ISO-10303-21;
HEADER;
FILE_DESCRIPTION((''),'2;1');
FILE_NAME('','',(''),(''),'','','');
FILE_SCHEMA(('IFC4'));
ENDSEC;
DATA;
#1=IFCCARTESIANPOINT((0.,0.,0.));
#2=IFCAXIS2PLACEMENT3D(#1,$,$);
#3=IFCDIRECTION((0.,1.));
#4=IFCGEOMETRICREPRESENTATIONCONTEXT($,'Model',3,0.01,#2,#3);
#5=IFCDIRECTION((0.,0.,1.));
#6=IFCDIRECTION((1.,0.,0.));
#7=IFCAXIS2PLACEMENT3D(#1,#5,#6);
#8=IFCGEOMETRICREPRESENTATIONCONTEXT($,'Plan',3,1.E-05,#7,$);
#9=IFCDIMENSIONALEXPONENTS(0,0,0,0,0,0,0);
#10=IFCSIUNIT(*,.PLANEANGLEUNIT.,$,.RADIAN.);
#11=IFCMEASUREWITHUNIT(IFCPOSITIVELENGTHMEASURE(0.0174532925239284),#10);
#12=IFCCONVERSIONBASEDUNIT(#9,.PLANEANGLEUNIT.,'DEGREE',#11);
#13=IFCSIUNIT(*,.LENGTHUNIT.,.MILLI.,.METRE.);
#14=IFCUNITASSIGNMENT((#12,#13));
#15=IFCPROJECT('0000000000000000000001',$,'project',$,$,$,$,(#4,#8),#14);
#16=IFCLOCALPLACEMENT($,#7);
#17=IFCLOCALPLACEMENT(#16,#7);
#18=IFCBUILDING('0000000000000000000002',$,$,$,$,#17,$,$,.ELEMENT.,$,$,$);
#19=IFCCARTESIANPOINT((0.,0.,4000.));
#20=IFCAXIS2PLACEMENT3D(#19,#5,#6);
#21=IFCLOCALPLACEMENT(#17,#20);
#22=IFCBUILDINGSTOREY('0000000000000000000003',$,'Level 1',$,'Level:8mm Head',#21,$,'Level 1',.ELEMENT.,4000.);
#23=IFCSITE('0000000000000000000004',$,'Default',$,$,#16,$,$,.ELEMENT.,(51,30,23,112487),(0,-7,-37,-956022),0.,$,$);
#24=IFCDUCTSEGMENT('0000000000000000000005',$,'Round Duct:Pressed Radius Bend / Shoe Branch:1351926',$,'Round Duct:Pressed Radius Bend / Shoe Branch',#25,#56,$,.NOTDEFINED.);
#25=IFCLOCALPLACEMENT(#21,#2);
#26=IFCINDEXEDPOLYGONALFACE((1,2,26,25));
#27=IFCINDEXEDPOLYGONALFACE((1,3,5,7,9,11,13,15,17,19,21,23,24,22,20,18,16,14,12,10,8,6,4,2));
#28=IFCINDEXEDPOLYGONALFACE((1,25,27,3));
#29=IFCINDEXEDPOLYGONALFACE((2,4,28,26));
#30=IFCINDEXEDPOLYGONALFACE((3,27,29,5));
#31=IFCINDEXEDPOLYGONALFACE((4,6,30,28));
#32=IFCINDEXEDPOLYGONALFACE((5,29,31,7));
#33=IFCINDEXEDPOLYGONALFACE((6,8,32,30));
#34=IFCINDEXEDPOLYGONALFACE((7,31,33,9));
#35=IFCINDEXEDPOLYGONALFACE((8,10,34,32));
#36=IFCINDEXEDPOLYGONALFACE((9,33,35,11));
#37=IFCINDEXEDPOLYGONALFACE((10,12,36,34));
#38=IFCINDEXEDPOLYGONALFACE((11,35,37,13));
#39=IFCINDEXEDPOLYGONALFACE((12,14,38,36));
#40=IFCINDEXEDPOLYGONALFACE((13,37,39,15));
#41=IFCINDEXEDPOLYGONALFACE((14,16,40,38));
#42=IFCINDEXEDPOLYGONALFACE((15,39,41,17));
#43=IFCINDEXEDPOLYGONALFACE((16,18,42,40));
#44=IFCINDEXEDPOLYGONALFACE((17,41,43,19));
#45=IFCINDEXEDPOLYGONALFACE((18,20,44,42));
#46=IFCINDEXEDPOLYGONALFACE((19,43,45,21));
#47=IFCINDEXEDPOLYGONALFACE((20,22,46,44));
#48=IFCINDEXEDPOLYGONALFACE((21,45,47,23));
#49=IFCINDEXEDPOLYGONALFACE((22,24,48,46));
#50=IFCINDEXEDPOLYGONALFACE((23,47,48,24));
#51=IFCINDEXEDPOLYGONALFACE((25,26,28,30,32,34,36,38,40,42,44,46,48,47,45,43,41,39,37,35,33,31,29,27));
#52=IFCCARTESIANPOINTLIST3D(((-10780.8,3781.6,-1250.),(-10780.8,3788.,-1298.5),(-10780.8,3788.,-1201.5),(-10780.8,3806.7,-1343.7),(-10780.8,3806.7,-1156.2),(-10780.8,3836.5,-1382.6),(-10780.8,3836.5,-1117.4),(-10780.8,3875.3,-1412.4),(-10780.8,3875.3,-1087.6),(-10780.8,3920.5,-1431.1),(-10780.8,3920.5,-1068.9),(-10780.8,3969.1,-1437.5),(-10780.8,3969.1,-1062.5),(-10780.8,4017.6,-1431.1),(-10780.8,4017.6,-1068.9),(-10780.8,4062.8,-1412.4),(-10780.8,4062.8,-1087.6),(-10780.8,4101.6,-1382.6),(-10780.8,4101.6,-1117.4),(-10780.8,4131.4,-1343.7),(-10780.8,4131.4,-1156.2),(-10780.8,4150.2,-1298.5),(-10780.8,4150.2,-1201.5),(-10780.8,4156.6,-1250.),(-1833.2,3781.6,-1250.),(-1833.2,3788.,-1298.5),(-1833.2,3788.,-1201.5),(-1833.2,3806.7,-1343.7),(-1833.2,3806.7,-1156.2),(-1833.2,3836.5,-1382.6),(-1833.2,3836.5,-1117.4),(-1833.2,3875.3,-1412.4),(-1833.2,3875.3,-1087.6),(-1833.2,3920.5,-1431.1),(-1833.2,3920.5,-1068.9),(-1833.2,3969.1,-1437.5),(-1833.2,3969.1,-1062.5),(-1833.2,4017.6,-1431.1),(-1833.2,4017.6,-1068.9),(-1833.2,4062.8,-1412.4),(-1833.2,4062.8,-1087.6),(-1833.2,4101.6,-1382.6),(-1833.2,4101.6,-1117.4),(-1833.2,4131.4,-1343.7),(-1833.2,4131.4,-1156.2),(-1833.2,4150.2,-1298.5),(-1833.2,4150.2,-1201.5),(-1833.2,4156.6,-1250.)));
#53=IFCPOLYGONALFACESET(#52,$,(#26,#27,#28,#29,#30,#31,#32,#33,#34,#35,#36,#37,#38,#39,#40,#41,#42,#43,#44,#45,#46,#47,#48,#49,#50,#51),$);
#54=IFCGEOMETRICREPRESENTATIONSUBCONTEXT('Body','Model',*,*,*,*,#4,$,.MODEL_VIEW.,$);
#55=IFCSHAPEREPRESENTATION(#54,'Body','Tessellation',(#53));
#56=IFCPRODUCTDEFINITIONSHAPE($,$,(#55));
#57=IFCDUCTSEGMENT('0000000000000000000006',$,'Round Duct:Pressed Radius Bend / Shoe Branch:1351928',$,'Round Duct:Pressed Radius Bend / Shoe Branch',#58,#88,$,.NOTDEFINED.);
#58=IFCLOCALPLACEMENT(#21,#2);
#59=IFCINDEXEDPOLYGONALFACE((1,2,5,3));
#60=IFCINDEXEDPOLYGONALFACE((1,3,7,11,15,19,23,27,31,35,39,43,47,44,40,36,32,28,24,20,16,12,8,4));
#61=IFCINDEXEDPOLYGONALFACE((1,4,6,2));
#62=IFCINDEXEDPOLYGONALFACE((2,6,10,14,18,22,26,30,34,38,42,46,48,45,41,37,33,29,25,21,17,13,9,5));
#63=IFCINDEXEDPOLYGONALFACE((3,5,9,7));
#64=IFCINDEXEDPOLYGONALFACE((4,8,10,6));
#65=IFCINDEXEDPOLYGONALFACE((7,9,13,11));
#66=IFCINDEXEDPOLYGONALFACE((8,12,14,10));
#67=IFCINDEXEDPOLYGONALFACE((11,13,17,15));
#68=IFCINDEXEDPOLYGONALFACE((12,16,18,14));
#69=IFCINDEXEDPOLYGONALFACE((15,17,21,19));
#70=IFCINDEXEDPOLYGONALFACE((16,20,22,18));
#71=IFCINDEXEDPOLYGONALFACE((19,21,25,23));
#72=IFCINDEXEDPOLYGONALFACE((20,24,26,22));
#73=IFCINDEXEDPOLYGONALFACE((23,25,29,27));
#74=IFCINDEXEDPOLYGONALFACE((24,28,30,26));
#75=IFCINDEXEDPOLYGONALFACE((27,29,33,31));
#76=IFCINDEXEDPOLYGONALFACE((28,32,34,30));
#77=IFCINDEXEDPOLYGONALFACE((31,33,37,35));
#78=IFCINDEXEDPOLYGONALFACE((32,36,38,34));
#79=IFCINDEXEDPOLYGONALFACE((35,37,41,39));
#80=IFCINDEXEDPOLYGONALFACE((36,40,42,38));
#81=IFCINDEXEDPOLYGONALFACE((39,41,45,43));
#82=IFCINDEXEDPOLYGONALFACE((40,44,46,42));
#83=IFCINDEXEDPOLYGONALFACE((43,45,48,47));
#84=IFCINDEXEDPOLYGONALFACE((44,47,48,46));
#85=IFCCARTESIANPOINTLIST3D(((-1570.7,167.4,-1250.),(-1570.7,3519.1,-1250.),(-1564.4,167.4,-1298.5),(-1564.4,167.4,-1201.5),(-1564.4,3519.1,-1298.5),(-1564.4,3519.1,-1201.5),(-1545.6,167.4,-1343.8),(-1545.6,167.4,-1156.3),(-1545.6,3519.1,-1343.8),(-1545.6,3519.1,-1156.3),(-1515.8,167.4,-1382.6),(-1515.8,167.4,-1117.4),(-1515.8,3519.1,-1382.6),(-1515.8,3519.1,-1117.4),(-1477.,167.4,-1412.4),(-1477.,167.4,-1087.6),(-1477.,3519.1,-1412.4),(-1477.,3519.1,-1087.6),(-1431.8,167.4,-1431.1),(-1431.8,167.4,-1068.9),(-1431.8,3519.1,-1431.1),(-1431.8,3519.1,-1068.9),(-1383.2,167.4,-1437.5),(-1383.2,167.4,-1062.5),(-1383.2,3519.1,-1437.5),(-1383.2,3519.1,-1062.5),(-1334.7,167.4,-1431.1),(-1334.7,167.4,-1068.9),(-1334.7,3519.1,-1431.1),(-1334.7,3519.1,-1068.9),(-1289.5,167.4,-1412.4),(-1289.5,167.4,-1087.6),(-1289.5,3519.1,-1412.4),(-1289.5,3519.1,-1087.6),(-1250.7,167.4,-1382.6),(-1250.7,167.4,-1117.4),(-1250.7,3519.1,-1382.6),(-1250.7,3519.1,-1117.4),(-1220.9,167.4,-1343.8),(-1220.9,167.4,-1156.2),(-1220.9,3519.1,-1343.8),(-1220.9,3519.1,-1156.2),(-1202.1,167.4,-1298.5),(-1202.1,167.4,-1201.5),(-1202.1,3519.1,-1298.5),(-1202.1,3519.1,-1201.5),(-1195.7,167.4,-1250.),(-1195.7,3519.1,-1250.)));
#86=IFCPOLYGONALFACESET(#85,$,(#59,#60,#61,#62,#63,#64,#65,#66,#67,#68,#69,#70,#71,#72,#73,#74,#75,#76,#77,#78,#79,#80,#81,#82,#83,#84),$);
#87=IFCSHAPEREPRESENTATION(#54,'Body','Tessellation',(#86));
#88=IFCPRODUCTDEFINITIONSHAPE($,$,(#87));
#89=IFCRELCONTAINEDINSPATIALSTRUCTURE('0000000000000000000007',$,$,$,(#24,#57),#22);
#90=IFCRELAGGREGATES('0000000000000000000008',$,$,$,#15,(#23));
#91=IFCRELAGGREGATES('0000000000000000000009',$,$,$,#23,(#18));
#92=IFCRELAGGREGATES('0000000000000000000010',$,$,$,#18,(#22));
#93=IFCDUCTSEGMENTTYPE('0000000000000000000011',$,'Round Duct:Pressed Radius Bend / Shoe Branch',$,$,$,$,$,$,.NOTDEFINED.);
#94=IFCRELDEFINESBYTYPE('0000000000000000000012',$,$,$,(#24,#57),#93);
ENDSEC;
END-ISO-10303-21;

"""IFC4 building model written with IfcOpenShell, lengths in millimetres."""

from ifc_helpers import new_model, entity, si_unit, converted_unit, direction, frame, origin, origin_with_axes, place, context, subcontext, project, spatial, arc, indexed_curve, outline, extrude, type_object, element, save


model = new_model("IFC4")

# Units and contexts
model_context = context("Model", 3, precision=0.01, world=origin(), true_north=direction((0.0, 1.0)))
plan_context = context("Plan", 3, precision=1e-05, world=origin_with_axes())
body_context = subcontext(model_context, "Body", "Model", "MODEL_VIEW")
ifc_project = project(units=[converted_unit("PLANEANGLEUNIT", "DEGREE", entity("IfcPositiveLengthMeasure", 0.0174532925239284), si_unit("PLANEANGLEUNIT", "RADIAN"), dimensions=[0, 0, 0, 0, 0, 0, 0]), si_unit("LENGTHUNIT", "METRE", prefix="MILLI")], contexts=[model_context, plan_context])

# Site, building, storey
site_placement = place(None, origin_with_axes())
site = spatial("IfcSite", under=ifc_project, at=site_placement, Name="Default", CompositionType="ELEMENT", RefLatitude=(51, 30, 23, 112487), RefLongitude=(0, -7, -37, -956022), RefElevation=0.0)
building_placement = place(site_placement, origin_with_axes())
building = spatial("IfcBuilding", under=site, at=building_placement, CompositionType="ELEMENT")
storey_placement = place(building_placement, frame((0.0, 0.0, 4000.0), z_axis=(0.0, 0.0, 1.0), x_axis=(1.0, 0.0, 0.0)))
storey = spatial("IfcBuildingStorey", under=building, at=storey_placement, Name="Level 1", ObjectType="Level:8mm Head", LongName="Level 1", CompositionType="ELEMENT", Elevation=4000.0)

# Duct segments
duct_segment_type = type_object("IfcDuctSegmentType", Name="Round Duct:Pressed Radius Bend / Shoe Branch", PredefinedType="NOTDEFINED")
duct_segment_1_placement = place(storey_placement, origin_with_axes())
element("IfcDuctSegment", 1, at=duct_segment_1_placement, inside=storey, type_object=duct_segment_type, Name="Round Duct:Pressed Radius Bend / Shoe Branch:1351926", ObjectType="Round Duct:Pressed Radius Bend / Shoe Branch", PredefinedType="NOTDEFINED", context=body_context, shape_type="SweptSolid", body=[
    extrude(outline(indexed_curve([(187.5, 0.0), (132.6, 132.6), (0.0, 187.5), (-132.6, 132.6), (-187.5, 0.0), (-132.6, -132.6), (0.0, -187.5), (132.6, -132.6)], segments=[arc(1, 2, 3), arc(3, 4, 5), arc(5, 6, 7), arc(7, 8, 1)], self_intersect=False)), frame((-10780.8, 3969.1, -1250.0), z_axis=(1.0, 0.0, 0.0), x_axis=(0.0, -1.0, 0.0)), (0.0, 0.0, 1.0), 8947.6),
])
duct_segment_2_placement = place(storey_placement, origin_with_axes())
element("IfcDuctSegment", 2, at=duct_segment_2_placement, inside=storey, type_object=duct_segment_type, Name="Round Duct:Pressed Radius Bend / Shoe Branch:1351928", ObjectType="Round Duct:Pressed Radius Bend / Shoe Branch", PredefinedType="NOTDEFINED", context=body_context, shape_type="SweptSolid", body=[
    extrude(outline(indexed_curve([(187.5, 0.0), (132.6, 132.6), (0.0, 187.5), (-132.6, 132.6), (-187.5, 0.0), (-132.6, -132.6), (0.0, -187.5), (132.6, -132.6)], segments=[arc(1, 2, 3), arc(3, 4, 5), arc(5, 6, 7), arc(7, 8, 1)], self_intersect=False)), frame((-1383.2, 167.4, -1250.0), z_axis=(0.0, 1.0, 0.0), x_axis=(1.0, 0.0, 0.0)), (0.0, 0.0, 1.0), 3351.7),
])

save(model, "model.ifc")
